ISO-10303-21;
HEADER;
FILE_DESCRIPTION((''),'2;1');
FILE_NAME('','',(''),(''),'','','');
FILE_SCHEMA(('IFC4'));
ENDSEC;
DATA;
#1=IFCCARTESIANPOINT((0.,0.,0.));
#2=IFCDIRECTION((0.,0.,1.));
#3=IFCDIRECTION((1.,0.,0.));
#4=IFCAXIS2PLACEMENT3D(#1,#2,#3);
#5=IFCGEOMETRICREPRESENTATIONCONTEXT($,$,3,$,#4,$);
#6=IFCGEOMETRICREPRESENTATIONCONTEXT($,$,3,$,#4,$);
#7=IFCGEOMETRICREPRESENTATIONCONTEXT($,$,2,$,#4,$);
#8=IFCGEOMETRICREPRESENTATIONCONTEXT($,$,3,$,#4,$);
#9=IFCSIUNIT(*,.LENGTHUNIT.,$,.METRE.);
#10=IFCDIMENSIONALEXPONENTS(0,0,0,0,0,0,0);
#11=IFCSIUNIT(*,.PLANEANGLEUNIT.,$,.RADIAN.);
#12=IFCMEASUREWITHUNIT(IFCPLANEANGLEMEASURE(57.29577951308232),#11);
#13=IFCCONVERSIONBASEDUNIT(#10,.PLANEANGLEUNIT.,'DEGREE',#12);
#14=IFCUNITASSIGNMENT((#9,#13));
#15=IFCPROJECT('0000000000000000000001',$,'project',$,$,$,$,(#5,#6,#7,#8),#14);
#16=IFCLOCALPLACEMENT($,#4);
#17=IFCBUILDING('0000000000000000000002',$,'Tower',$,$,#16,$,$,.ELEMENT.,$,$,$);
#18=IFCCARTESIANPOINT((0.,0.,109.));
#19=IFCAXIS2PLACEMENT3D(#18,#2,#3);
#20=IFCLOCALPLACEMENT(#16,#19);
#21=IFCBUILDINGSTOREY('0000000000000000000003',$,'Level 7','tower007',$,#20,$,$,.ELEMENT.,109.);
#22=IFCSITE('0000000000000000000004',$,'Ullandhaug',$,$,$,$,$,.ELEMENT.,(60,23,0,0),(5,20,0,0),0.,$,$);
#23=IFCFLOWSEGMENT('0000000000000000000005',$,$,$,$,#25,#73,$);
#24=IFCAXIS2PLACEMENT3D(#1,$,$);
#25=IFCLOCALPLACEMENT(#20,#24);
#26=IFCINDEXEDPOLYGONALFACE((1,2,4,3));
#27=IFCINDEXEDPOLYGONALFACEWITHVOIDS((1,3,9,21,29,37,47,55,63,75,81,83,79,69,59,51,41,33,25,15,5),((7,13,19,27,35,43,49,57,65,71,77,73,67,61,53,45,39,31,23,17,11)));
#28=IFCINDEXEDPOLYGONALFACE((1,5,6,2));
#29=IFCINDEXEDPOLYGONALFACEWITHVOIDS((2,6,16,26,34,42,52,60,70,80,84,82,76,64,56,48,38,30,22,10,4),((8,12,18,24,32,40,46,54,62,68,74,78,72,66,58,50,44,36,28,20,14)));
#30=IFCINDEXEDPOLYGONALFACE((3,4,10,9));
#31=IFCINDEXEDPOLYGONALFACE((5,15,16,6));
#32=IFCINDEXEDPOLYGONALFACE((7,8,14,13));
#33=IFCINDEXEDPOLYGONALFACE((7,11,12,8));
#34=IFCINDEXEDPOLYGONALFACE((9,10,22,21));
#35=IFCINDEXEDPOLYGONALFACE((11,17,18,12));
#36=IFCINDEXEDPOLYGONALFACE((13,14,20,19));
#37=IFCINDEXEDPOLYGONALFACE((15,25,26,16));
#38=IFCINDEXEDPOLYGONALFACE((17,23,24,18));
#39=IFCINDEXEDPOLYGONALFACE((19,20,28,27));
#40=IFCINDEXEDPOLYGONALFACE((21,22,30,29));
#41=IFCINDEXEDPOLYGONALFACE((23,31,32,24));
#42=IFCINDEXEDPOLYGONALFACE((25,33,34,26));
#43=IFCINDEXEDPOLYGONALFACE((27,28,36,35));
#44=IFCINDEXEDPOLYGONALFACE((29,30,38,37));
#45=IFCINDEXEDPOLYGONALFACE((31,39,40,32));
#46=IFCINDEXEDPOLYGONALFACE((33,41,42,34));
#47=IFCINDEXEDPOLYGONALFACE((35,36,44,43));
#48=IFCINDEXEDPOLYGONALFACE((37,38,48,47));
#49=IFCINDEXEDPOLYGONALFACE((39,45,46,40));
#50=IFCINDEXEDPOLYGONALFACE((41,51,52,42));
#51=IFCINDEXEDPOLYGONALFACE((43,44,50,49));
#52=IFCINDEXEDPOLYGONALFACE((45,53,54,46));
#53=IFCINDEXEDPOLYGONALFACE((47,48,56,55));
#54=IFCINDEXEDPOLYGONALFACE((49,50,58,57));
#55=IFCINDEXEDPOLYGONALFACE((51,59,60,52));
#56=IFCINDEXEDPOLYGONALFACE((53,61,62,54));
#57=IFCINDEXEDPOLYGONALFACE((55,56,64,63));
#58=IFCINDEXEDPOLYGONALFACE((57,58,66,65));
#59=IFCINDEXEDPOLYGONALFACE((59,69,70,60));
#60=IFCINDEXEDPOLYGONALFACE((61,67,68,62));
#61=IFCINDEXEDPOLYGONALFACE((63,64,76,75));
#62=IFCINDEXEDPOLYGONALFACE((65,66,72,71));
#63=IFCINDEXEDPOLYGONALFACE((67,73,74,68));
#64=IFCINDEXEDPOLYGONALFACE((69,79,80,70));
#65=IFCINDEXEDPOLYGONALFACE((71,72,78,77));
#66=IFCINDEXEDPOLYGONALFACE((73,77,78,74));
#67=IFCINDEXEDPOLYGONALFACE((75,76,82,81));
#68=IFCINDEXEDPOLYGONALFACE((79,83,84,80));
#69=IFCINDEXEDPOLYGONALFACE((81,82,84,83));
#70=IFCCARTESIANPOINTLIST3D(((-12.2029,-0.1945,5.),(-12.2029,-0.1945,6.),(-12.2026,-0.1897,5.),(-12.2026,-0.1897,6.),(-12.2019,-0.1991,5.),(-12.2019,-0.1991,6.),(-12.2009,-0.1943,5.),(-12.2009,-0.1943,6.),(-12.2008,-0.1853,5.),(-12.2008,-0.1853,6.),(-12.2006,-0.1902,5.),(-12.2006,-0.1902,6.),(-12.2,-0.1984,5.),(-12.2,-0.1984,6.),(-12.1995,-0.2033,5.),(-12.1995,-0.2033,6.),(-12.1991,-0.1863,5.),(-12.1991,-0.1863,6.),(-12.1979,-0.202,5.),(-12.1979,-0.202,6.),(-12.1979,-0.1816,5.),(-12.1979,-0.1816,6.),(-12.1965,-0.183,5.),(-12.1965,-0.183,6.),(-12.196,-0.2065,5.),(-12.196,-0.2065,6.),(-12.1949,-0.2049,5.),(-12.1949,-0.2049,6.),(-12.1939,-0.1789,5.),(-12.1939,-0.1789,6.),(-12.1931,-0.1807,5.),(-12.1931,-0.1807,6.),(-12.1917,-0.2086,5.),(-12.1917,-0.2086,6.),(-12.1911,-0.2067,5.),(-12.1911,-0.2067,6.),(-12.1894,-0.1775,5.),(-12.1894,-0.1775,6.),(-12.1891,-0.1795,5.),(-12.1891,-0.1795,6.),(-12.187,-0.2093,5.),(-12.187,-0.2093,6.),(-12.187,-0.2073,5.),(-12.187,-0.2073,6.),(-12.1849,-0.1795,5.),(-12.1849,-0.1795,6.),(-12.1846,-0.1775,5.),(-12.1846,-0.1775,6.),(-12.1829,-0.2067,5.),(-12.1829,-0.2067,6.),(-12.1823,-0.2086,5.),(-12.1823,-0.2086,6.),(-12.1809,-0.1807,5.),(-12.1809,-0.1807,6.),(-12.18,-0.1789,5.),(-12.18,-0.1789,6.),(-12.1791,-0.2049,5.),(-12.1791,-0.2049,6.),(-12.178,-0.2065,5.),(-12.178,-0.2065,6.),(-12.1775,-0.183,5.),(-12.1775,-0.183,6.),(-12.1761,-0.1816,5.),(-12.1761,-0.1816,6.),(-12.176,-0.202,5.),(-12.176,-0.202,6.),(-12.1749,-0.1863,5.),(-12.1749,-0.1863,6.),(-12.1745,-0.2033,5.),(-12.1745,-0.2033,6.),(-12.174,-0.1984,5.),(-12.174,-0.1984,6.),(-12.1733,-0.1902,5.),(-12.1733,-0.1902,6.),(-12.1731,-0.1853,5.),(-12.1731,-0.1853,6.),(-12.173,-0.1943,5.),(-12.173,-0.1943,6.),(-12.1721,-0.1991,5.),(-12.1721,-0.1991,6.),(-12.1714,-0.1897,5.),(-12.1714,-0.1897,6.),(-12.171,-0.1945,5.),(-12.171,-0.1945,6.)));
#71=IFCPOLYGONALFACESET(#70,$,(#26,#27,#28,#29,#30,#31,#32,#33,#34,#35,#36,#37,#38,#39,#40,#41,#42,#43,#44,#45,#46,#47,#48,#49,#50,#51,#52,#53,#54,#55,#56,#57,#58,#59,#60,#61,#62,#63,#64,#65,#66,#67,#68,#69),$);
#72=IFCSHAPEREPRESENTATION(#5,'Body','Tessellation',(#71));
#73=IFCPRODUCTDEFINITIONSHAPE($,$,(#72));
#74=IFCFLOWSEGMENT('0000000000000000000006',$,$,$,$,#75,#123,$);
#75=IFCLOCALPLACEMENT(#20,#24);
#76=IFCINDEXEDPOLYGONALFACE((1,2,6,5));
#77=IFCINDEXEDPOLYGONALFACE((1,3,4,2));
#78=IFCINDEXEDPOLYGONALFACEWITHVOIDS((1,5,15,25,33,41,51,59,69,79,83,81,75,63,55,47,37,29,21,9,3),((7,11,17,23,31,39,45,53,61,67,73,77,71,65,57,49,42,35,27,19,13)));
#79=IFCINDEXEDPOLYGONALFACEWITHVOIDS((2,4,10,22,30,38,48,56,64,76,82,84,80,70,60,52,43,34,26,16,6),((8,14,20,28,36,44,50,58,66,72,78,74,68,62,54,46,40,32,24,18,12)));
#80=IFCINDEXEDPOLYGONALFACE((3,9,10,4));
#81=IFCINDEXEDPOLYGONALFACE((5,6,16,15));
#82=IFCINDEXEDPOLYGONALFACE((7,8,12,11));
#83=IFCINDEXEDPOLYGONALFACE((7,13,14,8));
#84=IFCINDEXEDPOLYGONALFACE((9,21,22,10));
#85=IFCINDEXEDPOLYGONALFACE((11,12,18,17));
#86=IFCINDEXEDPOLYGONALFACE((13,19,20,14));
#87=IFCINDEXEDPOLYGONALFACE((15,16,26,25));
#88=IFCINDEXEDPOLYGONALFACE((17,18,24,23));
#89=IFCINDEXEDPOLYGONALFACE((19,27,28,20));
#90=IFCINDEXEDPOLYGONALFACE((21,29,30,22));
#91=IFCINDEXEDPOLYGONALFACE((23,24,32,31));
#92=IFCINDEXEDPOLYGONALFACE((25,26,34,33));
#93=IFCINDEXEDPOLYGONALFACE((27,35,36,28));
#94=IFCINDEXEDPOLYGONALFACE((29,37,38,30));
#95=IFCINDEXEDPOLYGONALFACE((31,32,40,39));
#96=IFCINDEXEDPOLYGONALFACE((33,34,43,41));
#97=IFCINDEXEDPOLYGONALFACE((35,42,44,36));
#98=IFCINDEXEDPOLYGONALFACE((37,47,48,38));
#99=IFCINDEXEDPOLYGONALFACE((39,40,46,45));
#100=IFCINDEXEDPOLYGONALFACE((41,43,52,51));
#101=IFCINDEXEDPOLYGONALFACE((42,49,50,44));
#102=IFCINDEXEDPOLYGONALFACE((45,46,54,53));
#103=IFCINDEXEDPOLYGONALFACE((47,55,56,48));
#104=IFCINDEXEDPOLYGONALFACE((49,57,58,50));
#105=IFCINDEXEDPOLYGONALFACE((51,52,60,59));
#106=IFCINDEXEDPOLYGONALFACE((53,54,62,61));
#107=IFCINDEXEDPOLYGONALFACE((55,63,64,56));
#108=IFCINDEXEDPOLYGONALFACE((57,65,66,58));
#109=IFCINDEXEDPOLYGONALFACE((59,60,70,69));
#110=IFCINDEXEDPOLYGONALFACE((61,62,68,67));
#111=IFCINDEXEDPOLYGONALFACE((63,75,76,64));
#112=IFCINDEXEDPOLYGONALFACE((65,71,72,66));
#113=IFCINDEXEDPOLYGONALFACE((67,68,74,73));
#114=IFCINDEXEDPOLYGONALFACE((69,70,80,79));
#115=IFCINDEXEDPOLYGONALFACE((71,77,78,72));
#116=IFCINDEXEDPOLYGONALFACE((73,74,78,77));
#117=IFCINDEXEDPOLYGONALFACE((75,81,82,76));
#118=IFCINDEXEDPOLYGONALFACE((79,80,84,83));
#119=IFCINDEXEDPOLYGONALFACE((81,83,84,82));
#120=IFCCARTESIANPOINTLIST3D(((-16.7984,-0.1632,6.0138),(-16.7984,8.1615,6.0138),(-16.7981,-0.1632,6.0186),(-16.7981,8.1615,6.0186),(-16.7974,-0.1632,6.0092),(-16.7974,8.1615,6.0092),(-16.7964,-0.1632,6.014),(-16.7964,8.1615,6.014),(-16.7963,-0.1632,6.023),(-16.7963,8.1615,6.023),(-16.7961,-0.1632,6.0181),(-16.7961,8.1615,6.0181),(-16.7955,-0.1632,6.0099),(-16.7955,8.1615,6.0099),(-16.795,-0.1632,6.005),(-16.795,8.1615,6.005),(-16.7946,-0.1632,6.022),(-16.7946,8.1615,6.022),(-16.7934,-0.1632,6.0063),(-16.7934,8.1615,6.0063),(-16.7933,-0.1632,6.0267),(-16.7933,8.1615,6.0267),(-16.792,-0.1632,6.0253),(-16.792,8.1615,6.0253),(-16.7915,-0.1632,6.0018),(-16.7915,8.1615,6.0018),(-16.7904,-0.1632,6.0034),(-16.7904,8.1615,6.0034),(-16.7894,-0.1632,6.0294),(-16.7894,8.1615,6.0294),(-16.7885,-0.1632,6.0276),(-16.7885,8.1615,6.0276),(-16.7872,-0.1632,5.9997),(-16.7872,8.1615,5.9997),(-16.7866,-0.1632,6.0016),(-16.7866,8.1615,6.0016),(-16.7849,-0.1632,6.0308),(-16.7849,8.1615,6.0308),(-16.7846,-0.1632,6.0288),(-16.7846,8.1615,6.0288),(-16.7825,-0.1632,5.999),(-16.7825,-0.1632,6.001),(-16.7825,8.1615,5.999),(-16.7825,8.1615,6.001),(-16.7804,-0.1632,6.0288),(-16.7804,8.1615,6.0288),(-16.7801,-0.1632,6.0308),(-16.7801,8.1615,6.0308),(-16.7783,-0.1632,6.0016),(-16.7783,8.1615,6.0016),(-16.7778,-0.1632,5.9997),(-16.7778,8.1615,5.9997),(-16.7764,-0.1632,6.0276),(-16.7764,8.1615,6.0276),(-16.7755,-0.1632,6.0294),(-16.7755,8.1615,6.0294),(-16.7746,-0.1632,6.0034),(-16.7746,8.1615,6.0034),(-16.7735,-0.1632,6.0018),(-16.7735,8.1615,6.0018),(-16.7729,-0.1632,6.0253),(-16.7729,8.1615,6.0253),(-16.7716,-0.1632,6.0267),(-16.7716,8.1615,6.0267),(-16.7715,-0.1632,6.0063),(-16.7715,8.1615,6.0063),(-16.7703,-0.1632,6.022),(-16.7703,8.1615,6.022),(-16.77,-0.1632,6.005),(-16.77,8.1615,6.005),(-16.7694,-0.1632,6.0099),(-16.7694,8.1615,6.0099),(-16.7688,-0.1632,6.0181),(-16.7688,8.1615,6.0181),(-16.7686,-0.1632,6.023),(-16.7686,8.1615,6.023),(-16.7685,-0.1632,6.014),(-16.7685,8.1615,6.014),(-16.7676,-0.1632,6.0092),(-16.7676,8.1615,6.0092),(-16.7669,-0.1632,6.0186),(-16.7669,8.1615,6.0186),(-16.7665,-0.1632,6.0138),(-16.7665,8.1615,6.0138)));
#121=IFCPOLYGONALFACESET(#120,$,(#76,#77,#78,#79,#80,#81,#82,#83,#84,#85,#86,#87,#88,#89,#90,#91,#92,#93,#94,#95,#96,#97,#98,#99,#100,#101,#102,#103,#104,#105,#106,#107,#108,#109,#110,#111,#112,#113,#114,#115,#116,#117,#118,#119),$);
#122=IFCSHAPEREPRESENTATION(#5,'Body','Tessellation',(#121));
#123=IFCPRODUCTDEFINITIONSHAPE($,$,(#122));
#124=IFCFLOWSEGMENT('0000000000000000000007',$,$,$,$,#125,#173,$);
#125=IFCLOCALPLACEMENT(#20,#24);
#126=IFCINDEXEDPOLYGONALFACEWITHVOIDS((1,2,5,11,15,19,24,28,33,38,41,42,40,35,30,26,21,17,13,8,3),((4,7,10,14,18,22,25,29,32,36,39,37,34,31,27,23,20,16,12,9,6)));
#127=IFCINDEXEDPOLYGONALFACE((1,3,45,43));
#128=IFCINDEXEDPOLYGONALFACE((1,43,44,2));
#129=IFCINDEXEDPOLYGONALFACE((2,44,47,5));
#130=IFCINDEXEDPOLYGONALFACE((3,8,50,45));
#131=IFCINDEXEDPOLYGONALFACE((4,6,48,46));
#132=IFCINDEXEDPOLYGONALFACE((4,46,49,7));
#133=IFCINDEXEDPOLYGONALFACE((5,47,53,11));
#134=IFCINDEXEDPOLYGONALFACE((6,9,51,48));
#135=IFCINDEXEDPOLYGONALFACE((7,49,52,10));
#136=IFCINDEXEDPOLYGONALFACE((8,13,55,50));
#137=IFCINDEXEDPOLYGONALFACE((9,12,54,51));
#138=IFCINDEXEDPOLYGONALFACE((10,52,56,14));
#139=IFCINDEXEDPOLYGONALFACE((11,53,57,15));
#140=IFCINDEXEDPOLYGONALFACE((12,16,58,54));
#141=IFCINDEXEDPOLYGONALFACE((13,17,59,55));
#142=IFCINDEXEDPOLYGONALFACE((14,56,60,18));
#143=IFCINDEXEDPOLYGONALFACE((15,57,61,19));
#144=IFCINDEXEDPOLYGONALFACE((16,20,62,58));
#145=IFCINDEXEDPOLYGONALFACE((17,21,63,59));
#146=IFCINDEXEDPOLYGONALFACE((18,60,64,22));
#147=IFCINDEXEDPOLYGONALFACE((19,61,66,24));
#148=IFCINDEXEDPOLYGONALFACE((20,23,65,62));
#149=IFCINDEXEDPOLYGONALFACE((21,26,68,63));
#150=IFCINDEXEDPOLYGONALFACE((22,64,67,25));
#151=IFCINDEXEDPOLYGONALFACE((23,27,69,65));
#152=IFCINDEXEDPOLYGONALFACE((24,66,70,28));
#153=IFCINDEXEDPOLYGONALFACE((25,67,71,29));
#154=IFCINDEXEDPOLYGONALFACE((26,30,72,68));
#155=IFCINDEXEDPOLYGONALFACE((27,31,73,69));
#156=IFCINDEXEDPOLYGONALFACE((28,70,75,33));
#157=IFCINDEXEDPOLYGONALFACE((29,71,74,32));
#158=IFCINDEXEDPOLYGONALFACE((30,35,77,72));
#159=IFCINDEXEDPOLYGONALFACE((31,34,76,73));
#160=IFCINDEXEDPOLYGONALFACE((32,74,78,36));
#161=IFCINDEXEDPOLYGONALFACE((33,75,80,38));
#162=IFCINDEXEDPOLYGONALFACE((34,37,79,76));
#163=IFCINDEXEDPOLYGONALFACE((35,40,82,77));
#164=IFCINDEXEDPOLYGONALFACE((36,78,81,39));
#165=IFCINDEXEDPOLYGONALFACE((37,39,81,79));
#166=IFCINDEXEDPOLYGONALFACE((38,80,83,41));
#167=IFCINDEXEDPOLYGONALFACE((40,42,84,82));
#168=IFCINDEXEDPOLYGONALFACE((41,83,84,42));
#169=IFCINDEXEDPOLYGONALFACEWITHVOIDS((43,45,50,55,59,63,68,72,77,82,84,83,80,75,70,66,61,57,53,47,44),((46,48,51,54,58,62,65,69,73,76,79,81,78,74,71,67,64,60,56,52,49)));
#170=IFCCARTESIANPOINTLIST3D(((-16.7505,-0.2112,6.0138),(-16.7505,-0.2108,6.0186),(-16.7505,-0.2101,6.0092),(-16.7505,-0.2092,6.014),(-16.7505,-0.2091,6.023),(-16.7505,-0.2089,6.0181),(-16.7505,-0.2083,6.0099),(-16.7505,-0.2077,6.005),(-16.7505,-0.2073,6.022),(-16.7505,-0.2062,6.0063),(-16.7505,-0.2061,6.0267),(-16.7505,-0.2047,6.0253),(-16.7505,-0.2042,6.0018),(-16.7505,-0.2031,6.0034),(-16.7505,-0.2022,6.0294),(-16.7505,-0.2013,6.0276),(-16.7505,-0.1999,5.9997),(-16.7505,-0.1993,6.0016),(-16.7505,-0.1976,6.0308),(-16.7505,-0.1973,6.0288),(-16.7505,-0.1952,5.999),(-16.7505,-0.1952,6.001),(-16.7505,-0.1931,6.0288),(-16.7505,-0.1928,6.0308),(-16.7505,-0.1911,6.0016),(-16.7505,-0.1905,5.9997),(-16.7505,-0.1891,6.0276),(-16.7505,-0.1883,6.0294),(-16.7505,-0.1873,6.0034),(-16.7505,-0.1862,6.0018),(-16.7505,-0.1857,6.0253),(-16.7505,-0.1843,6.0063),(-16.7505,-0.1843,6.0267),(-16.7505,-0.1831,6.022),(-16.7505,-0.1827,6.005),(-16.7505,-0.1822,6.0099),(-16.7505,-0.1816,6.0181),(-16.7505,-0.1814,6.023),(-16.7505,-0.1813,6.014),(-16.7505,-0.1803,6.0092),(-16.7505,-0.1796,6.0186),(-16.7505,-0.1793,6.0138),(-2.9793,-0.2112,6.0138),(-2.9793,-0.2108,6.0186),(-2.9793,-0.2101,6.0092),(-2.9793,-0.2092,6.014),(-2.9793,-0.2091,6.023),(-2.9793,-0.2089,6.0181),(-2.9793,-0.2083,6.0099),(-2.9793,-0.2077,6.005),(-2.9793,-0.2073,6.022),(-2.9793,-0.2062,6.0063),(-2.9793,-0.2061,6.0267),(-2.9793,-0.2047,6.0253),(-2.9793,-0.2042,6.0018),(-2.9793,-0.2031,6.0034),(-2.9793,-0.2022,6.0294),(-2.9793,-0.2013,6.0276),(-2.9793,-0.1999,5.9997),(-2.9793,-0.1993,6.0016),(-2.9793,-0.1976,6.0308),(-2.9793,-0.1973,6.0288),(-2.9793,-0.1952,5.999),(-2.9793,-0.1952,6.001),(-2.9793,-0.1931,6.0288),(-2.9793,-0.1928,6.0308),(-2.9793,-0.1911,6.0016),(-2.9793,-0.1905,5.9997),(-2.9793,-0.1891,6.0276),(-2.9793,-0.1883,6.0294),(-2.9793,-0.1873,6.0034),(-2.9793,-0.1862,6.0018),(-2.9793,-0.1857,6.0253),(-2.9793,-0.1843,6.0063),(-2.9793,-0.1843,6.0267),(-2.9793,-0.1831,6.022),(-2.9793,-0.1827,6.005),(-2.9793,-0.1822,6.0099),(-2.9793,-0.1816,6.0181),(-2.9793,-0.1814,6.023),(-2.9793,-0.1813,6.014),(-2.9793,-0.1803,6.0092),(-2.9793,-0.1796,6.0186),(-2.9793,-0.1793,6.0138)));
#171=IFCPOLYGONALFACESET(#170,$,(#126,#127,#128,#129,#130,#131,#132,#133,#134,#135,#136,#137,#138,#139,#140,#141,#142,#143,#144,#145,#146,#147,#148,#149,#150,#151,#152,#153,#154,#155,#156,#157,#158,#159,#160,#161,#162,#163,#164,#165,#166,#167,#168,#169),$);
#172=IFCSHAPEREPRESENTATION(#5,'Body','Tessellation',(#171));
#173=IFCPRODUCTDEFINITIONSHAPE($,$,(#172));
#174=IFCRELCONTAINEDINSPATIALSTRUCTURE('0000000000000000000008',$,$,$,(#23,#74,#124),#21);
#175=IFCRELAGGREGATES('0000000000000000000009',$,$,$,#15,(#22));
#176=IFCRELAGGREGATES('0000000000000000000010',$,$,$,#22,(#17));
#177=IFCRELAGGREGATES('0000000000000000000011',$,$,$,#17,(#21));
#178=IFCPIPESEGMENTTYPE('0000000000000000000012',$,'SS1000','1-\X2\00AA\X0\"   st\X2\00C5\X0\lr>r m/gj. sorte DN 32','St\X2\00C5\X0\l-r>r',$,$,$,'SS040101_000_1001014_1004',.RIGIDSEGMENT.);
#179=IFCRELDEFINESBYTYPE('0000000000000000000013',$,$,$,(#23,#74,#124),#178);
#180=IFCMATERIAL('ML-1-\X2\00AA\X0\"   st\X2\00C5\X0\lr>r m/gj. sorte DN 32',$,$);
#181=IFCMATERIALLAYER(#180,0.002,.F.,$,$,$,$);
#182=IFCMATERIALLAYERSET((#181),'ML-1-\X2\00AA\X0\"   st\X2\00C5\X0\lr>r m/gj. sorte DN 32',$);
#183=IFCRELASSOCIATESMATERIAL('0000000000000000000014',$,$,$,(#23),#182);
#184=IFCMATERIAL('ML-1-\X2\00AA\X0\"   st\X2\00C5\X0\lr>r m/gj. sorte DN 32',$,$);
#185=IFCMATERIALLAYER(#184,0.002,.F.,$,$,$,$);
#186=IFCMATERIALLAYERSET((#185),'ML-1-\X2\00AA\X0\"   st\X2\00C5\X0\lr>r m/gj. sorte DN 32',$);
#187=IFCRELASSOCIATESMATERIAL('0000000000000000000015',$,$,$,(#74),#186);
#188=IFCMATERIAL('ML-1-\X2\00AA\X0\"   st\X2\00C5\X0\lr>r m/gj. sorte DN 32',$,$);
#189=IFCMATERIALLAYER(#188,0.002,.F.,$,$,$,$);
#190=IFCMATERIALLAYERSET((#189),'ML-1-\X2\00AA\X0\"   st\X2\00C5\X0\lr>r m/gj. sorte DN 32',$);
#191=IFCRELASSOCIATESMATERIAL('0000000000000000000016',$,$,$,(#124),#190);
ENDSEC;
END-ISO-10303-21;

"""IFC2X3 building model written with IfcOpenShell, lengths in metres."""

from ifc_helpers import new_model, entity, si_unit, converted_unit, frame, origin_with_axes, origin_2d_with_axis, place, context, project, spatial, hollow_circle, extrude, material, layer, layer_set, layer_usage, type_object, element, save


model = new_model("IFC2X3")

# Units and contexts
context_of_model_1 = context(None, 3, world=origin_with_axes())
context_of_model_2 = context(None, 3, world=origin_with_axes())
context_of_model_3 = context(None, 2, world=origin_with_axes())
context_of_model_4 = context(None, 3, world=origin_with_axes())
ifc_project = project(units=[si_unit("LENGTHUNIT", "METRE"), converted_unit("PLANEANGLEUNIT", "DEGREE", entity("IfcPlaneAngleMeasure", 57.29577951308232), si_unit("PLANEANGLEUNIT", "RADIAN"), dimensions=[0, 0, 0, 0, 0, 0, 0])], contexts=[context_of_model_1, context_of_model_2, context_of_model_3, context_of_model_4])

# Site, building, storey
site = spatial("IfcSite", under=ifc_project, Name="Ullandhaug", CompositionType="ELEMENT", RefLatitude=(60, 23, 0, 0), RefLongitude=(5, 20, 0, 0), RefElevation=0.0)
building_placement = place(None, origin_with_axes())
building = spatial("IfcBuilding", under=site, at=building_placement, Name="Tower", CompositionType="ELEMENT")
storey_placement = place(building_placement, frame((0.0, 0.0, 109.0), z_axis=(0.0, 0.0, 1.0), x_axis=(1.0, 0.0, 0.0)))
storey = spatial("IfcBuildingStorey", under=building, at=storey_placement, Name="Level 7", Description="tower007", CompositionType="ELEMENT", Elevation=109.0)

# Flow segments
pipe_segment_type_1 = type_object("IfcPipeSegmentType", Name="SS1000", Description="1-ª\"   stÅlr>r m/gj. sorte DN 32", ApplicableOccurrence="StÅl-r>r", ElementType="SS040101_000_1001014_1004", PredefinedType="RIGIDSEGMENT")
ifc_material_1 = material(Name="ML-1-ª\"   stÅlr>r m/gj. sorte DN 32")
ifc_layer_1 = layer(ifc_material_1, 0.002, ventilated=False)
ifc_layer_set_1 = layer_set([ifc_layer_1], Name="ML-1-ª\"   stÅlr>r m/gj. sorte DN 32")
ifc_layer_usage_1 = layer_usage(ifc_layer_set_1, "AXIS2", "POSITIVE", 0.0)
flow_segment_1_placement = place(storey_placement, frame((-12.187, -0.1933, 5.0), z_axis=(0.0, 0.0, 1.0), x_axis=(0.0, -1.0, 0.0)))
element("IfcFlowSegment", 1, at=flow_segment_1_placement, inside=storey, type_object=pipe_segment_type_1, material=ifc_layer_usage_1, context=context_of_model_1, shape_type="SweptSolid", body=[
    extrude(hollow_circle(Radius=0.016, WallThickness=0.002, at=origin_2d_with_axis()), origin_with_axes(), (0.0, 0.0, 1.0), 1.0),
])
ifc_material_2 = material(Name="ML-1-ª\"   stÅlr>r m/gj. sorte DN 32")
ifc_layer_2 = layer(ifc_material_2, 0.002, ventilated=False)
ifc_layer_set_2 = layer_set([ifc_layer_2], Name="ML-1-ª\"   stÅlr>r m/gj. sorte DN 32")
ifc_layer_usage_2 = layer_usage(ifc_layer_set_2, "AXIS2", "POSITIVE", 0.0)
flow_segment_2_placement = place(storey_placement, frame((-16.7825, 8.1615, 6.015), z_axis=(0.0, -1.0, 0.0), x_axis=(0.0, 0.0, -1.0)))
element("IfcFlowSegment", 2, at=flow_segment_2_placement, inside=storey, type_object=pipe_segment_type_1, material=ifc_layer_usage_2, context=context_of_model_1, shape_type="SweptSolid", body=[
    extrude(hollow_circle(Radius=0.016, WallThickness=0.002, at=origin_2d_with_axis()), origin_with_axes(), (0.0, 0.0, 1.0), 8.3247),
])
ifc_material_3 = material(Name="ML-1-ª\"   stÅlr>r m/gj. sorte DN 32")
ifc_layer_3 = layer(ifc_material_3, 0.002, ventilated=False)
ifc_layer_set_3 = layer_set([ifc_layer_3], Name="ML-1-ª\"   stÅlr>r m/gj. sorte DN 32")
ifc_layer_usage_3 = layer_usage(ifc_layer_set_3, "AXIS2", "POSITIVE", 0.0)
flow_segment_3_placement = place(storey_placement, frame((-16.7505, -0.1952, 6.015), z_axis=(1.0, 0.0, 0.0), x_axis=(0.0, 0.0, -1.0)))
element("IfcFlowSegment", 3, at=flow_segment_3_placement, inside=storey, type_object=pipe_segment_type_1, material=ifc_layer_usage_3, context=context_of_model_1, shape_type="SweptSolid", body=[
    extrude(hollow_circle(Radius=0.016, WallThickness=0.002, at=origin_2d_with_axis()), origin_with_axes(), (0.0, 0.0, 1.0), 13.7711),
])

save(model, "model.ifc")
